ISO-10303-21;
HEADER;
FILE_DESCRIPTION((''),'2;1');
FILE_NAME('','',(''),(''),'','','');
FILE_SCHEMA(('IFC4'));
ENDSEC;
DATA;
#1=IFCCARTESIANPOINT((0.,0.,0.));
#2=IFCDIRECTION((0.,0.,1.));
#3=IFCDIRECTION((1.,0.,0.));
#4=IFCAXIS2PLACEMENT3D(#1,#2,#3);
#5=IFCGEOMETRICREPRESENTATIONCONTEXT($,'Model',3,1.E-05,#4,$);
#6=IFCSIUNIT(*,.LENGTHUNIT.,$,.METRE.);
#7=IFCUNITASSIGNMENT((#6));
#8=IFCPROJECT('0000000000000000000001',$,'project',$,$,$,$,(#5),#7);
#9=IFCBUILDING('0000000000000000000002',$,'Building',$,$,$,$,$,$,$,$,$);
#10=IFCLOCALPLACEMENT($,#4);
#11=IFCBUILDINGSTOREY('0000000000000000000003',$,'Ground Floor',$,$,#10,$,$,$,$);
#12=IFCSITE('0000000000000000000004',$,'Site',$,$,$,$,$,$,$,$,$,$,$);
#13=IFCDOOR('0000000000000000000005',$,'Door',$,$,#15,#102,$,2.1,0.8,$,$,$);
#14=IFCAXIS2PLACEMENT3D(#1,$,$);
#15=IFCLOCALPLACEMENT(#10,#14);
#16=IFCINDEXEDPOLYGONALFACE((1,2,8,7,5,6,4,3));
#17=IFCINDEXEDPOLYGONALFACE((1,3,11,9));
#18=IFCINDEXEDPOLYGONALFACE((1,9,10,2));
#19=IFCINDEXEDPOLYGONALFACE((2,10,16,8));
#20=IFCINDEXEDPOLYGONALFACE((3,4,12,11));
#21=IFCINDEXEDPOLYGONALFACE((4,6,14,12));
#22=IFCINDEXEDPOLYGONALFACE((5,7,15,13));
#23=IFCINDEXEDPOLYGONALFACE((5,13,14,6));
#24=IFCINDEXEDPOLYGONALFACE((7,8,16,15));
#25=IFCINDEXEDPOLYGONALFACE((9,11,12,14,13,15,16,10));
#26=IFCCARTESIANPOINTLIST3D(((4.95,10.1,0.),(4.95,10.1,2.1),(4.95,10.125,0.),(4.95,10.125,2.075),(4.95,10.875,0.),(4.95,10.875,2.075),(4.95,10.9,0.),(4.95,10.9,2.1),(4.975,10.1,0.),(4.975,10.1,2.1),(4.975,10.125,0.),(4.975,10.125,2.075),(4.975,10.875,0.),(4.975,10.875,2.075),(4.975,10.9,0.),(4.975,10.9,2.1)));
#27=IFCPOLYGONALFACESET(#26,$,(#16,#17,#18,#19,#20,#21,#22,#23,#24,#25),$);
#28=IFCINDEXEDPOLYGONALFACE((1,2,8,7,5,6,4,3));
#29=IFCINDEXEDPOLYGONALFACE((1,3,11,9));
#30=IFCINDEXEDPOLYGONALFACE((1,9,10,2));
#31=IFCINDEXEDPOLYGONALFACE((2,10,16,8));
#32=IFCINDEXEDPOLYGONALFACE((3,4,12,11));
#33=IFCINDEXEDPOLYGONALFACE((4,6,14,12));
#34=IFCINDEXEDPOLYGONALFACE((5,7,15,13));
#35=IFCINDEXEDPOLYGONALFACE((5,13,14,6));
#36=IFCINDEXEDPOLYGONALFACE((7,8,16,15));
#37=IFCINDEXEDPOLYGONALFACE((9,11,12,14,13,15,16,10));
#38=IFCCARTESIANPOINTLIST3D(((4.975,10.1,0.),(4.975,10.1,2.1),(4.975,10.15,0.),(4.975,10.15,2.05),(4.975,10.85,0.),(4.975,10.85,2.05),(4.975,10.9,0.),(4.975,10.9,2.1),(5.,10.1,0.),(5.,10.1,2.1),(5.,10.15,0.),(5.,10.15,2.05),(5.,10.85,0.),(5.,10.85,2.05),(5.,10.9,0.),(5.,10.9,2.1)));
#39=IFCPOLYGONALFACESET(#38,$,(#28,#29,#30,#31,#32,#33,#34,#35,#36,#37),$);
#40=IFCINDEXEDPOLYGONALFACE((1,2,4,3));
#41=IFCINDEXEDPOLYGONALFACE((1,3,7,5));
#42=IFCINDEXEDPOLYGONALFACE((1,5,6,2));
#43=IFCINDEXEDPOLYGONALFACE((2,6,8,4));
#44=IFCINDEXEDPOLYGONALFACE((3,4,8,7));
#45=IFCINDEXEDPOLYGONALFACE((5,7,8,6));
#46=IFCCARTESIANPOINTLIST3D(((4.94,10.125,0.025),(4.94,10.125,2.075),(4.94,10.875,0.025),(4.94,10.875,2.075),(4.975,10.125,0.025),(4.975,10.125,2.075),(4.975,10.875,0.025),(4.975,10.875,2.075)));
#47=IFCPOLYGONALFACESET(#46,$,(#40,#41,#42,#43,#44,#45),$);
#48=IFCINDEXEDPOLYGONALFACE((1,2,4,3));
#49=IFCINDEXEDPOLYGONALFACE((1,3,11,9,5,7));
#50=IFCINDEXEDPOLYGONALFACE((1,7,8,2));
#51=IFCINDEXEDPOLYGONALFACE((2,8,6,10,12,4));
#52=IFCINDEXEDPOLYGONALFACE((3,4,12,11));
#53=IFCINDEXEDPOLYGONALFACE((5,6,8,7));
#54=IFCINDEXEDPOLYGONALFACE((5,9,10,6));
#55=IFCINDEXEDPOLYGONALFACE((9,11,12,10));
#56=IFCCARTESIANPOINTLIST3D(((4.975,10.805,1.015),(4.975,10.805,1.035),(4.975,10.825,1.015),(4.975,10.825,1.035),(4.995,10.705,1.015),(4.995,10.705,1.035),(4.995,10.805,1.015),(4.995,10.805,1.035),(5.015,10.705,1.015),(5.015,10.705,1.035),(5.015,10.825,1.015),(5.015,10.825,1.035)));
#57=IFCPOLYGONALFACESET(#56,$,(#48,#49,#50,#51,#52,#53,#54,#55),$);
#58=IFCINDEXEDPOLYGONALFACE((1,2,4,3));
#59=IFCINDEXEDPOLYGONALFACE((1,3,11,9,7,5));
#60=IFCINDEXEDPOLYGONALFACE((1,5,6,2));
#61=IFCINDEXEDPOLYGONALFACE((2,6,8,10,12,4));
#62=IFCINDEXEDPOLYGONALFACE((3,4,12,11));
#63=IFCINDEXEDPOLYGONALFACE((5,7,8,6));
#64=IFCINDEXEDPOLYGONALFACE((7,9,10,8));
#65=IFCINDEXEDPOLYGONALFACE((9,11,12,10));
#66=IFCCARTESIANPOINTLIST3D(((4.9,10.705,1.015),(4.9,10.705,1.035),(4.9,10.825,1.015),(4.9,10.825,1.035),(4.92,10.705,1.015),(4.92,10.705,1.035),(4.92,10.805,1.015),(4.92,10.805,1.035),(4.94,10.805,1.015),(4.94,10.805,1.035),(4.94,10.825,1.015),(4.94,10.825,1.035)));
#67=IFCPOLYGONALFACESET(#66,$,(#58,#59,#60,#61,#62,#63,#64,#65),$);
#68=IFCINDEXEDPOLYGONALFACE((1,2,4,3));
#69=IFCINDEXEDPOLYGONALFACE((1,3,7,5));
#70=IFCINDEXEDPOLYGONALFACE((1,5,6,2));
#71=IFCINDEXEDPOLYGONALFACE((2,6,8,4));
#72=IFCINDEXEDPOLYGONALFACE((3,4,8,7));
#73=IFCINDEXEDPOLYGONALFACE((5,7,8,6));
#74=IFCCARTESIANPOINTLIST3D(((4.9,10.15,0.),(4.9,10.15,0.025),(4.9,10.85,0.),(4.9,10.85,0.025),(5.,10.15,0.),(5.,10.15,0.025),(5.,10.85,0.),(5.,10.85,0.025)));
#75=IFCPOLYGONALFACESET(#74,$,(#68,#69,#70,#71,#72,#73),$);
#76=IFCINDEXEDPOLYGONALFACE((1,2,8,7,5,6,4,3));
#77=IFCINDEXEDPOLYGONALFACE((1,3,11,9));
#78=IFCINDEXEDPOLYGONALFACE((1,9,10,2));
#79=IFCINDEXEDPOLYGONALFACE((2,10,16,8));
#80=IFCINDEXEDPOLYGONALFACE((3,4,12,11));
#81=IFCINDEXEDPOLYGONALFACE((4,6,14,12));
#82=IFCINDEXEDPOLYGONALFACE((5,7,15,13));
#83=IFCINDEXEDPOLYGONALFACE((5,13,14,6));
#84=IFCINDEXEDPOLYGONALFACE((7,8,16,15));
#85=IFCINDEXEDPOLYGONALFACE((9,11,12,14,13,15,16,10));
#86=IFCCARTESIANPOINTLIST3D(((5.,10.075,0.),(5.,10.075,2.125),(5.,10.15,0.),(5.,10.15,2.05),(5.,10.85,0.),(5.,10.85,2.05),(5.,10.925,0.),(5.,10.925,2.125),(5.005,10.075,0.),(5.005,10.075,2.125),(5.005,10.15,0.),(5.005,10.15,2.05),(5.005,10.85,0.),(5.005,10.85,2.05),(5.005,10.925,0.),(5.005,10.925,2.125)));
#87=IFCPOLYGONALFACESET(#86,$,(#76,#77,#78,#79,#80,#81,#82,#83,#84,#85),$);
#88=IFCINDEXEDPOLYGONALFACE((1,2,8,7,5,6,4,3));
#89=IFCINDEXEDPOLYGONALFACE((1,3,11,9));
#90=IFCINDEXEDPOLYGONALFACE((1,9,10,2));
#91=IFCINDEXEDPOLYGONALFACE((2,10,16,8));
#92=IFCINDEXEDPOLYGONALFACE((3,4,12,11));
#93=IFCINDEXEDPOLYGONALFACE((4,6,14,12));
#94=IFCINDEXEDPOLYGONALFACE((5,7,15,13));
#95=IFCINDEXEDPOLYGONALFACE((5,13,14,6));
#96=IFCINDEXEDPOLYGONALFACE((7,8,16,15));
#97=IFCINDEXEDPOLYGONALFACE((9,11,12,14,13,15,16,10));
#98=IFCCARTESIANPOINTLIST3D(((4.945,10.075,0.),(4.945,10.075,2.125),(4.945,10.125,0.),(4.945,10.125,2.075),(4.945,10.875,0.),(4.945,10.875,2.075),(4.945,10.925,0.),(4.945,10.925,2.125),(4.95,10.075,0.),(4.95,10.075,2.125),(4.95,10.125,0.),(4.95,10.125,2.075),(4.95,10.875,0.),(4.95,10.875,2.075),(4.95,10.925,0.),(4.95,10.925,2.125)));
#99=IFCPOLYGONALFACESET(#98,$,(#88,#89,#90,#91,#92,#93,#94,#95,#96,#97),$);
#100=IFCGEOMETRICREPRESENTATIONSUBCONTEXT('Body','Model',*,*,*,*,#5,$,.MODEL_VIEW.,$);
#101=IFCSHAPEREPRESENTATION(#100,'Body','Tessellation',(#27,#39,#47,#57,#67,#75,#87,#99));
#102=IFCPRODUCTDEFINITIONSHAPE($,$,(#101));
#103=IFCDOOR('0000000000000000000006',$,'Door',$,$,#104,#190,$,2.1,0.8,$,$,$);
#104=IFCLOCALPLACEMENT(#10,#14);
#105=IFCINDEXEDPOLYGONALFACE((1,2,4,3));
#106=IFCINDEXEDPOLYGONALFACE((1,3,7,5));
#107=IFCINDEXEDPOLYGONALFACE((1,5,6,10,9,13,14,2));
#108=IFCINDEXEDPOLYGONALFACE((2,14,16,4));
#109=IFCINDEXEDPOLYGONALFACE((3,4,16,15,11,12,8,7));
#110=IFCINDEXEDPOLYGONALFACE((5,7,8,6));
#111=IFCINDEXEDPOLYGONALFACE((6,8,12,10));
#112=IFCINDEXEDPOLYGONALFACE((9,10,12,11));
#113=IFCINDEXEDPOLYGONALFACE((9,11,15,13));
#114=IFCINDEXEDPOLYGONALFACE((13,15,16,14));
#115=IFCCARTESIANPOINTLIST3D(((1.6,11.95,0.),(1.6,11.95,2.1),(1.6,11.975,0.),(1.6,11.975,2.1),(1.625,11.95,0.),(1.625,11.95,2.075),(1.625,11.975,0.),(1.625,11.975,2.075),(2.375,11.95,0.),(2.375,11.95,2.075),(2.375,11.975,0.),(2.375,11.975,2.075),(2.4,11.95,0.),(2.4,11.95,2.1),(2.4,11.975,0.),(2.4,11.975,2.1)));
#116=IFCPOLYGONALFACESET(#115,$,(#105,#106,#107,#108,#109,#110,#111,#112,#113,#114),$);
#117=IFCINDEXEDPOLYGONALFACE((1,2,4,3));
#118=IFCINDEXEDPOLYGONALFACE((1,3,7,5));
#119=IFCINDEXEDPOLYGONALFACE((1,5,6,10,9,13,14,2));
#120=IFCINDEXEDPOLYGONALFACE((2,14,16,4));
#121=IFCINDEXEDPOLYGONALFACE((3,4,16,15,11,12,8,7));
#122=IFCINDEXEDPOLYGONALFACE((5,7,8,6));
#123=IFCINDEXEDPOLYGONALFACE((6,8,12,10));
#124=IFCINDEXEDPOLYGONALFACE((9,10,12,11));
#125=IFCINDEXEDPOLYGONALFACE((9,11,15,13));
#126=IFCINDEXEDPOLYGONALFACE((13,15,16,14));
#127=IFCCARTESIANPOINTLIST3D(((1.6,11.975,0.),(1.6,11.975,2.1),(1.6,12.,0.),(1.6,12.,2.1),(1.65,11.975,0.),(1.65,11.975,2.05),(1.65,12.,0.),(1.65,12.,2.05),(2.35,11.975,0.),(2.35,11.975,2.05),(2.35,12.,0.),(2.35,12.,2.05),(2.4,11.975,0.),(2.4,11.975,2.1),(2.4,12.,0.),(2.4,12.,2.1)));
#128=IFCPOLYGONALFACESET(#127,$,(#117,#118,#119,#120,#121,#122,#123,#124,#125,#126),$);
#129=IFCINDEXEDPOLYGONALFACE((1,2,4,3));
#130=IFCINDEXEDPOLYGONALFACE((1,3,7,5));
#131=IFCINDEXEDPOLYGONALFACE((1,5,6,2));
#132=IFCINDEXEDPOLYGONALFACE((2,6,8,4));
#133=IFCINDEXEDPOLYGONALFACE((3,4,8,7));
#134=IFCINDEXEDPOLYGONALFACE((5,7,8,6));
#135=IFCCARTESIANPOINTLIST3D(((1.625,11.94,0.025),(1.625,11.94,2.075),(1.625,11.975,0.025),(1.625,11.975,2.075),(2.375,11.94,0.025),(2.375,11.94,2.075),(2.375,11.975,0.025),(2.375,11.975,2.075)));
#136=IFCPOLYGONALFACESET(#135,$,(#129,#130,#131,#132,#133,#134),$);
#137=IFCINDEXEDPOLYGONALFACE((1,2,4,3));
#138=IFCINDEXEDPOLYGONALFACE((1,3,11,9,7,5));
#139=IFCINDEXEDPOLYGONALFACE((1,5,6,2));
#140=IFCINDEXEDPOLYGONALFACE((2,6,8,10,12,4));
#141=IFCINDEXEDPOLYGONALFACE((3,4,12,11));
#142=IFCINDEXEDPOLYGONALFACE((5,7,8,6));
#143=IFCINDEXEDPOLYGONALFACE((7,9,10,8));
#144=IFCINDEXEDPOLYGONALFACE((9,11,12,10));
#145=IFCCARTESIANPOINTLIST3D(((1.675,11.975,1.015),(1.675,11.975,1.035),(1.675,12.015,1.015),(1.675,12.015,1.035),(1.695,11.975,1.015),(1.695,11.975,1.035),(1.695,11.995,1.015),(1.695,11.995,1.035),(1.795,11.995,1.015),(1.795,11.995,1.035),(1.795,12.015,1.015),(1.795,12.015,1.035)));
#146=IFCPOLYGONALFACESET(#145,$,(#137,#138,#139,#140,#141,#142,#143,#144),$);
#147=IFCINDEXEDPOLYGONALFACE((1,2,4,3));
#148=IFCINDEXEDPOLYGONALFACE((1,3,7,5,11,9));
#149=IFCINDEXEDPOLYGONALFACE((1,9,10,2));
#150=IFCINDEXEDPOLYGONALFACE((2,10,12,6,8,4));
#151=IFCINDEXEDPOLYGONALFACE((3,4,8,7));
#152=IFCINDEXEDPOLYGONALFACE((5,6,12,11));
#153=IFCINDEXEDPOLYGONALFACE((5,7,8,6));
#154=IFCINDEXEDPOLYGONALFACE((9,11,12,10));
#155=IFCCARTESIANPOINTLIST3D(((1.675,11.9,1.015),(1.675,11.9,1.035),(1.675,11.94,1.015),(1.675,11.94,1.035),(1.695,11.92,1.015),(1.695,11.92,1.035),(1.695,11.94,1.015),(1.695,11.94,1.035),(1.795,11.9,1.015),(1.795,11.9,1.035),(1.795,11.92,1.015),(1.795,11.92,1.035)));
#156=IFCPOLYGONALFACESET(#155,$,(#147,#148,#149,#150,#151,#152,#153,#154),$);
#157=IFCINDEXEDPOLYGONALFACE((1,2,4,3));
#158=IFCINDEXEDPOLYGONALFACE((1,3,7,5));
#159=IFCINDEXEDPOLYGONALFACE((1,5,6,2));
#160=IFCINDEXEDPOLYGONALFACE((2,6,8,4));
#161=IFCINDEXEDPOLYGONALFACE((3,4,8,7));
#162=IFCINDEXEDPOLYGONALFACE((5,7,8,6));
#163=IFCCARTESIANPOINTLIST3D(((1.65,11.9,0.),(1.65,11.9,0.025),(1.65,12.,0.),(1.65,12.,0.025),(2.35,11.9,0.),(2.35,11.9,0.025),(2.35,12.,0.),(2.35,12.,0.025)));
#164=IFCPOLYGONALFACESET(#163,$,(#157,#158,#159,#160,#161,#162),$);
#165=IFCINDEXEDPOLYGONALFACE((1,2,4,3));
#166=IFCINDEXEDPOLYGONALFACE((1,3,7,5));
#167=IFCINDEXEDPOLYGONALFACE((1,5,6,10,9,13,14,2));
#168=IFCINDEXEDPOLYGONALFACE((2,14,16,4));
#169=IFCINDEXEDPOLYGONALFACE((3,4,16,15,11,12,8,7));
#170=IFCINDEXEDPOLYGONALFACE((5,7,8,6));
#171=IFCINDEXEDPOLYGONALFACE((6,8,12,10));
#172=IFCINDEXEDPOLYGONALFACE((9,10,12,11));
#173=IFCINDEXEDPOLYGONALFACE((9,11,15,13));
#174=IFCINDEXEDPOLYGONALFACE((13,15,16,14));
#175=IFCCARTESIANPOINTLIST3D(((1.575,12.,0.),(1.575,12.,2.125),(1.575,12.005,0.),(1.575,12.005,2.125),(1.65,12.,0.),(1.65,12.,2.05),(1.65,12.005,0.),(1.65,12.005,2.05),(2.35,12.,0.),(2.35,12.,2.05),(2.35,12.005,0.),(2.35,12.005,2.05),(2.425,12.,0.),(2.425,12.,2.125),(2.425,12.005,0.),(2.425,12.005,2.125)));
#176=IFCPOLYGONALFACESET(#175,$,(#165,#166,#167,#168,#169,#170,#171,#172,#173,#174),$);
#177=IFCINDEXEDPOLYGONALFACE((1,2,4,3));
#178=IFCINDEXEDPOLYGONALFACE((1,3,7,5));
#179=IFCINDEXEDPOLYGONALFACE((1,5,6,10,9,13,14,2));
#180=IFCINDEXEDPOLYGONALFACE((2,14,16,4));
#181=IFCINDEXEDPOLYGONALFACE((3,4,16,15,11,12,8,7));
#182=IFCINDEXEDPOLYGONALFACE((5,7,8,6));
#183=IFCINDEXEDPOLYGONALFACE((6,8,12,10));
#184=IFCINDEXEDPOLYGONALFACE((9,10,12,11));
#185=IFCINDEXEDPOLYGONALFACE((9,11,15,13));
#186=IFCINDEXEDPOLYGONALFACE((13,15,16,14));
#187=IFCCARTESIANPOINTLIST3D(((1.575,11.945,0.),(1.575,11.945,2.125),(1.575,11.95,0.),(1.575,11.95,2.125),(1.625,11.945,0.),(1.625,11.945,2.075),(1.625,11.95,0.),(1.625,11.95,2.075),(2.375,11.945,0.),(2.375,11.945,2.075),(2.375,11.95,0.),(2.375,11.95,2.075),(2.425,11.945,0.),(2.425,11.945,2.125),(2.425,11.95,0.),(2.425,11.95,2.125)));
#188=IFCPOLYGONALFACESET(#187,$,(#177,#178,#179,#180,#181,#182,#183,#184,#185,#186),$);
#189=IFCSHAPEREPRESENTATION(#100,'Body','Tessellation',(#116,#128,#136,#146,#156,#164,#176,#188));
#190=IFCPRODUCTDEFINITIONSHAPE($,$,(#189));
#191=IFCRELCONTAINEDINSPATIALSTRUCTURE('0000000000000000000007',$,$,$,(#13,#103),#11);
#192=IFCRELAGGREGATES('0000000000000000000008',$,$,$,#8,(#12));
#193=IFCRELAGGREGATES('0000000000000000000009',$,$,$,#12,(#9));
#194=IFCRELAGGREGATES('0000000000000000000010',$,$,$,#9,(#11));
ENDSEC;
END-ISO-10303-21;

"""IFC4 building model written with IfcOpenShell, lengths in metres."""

from ifc_helpers import new_model, si_unit, frame, origin_with_axes, place, context, subcontext, project, spatial, line, indexed_curve, outline, extrude, element, save


model = new_model("IFC4")

# Units and contexts
model_context = context("Model", 3, precision=1e-05, world=origin_with_axes())
body_context = subcontext(model_context, "Body", "Model", "MODEL_VIEW")
ifc_project = project(units=[si_unit("LENGTHUNIT", "METRE")], contexts=[model_context])

# Site, building, storey
site = spatial("IfcSite", under=ifc_project, Name="Site")
building = spatial("IfcBuilding", under=site, Name="Building")
storey_placement = place(None, origin_with_axes())
storey = spatial("IfcBuildingStorey", under=building, at=storey_placement, Name="Ground Floor")

# Doors
door_1_placement = place(storey_placement, frame((5.0, 10.1, 0.0), z_axis=(0.0, 0.0, 1.0), x_axis=(0.0, 1.0, 0.0)))
element("IfcDoor", 1, at=door_1_placement, inside=storey, Name="Door", OverallHeight=2.1, OverallWidth=0.8, context=body_context, shape_type="SweptSolid", body=[
    extrude(outline(indexed_curve([(0.0, 0.0), (0.0, 2.1), (0.8, 2.1), (0.8, 0.0), (0.775, 0.0), (0.775, 2.075), (0.025, 2.075), (0.025, 0.0)], segments=[line(1, 2, 3, 4, 5, 6, 7, 8, 1)])), frame((0.0, 0.025, 0.0), z_axis=(0.0, -1.0, 0.0), x_axis=(1.0, 0.0, 0.0)), (0.0, 0.0, -1.0), 0.025),
    extrude(outline(indexed_curve([(0.0, 0.0), (0.0, 2.1), (0.8, 2.1), (0.8, 0.0), (0.75, 0.0), (0.75, 2.05), (0.05, 2.05), (0.05, 0.0)], segments=[line(1, 2, 3, 4, 5, 6, 7, 8, 1)])), frame((0.0, 0.0, 0.0), z_axis=(0.0, -1.0, 0.0), x_axis=(1.0, 0.0, 0.0)), (0.0, 0.0, -1.0), 0.025),
    extrude(outline(indexed_curve([(0.0, 0.0), (0.75, 0.0), (0.75, 0.035), (0.0, 0.035)], segments=[line(1, 2, 3, 4, 1)])), frame((0.025, 0.025, 0.025), z_axis=(0.0, 0.0, 1.0), x_axis=(1.0, 0.0, 0.0)), (0.0, 0.0, 1.0), 2.05),
    extrude(outline(indexed_curve([(0.0, 0.0), (0.0, -0.04), (-0.12, -0.04), (-0.12, -0.02), (-0.02, -0.02), (-0.02, 0.0)], segments=[line(1, 2, 3, 4, 5, 6, 1)])), frame((0.725, 0.025, 1.015), z_axis=(0.0, 0.0, 1.0), x_axis=(1.0, 0.0, 0.0)), (0.0, 0.0, 1.0), 0.02),
    extrude(outline(indexed_curve([(0.0, 0.0), (0.0, 0.04), (-0.12, 0.04), (-0.12, 0.02), (-0.02, 0.02), (-0.02, 0.0)], segments=[line(1, 2, 3, 4, 5, 6, 1)])), frame((0.725, 0.06, 1.015), z_axis=(0.0, 0.0, 1.0), x_axis=(1.0, 0.0, 0.0)), (0.0, 0.0, 1.0), 0.02),
    extrude(outline(indexed_curve([(0.0, 0.0), (0.7, 0.0), (0.7, 0.1), (0.0, 0.1)], segments=[line(1, 2, 3, 4, 1)])), frame((0.05, 0.0, 0.0), z_axis=(0.0, 0.0, 1.0), x_axis=(1.0, 0.0, 0.0)), (0.0, 0.0, 1.0), 0.025),
    extrude(outline(indexed_curve([(0.0, 0.0), (0.0, 2.125), (0.85, 2.125), (0.85, 0.0), (0.775, 0.0), (0.775, 2.05), (0.075, 2.05), (0.075, 0.0)], segments=[line(1, 2, 3, 4, 5, 6, 7, 8, 1)])), frame((-0.025, -0.005, 0.0), z_axis=(0.0, -1.0, 0.0), x_axis=(1.0, 0.0, 0.0)), (0.0, 0.0, -1.0), 0.005),
    extrude(outline(indexed_curve([(0.0, 0.0), (0.0, 2.125), (0.85, 2.125), (0.85, 0.0), (0.8, 0.0), (0.8, 2.075), (0.05, 2.075), (0.05, 0.0)], segments=[line(1, 2, 3, 4, 5, 6, 7, 8, 1)])), frame((-0.025, 0.05, 0.0), z_axis=(0.0, -1.0, 0.0), x_axis=(1.0, 0.0, 0.0)), (0.0, 0.0, -1.0), 0.005),
])
door_2_placement = place(storey_placement, frame((2.4, 12.0, 0.0), z_axis=(0.0, 0.0, 1.0), x_axis=(-1.0, 0.0, 0.0)))
element("IfcDoor", 2, at=door_2_placement, inside=storey, Name="Door", OverallHeight=2.1, OverallWidth=0.8, context=body_context, shape_type="SweptSolid", body=[
    extrude(outline(indexed_curve([(0.0, 0.0), (0.0, 2.1), (0.8, 2.1), (0.8, 0.0), (0.775, 0.0), (0.775, 2.075), (0.025, 2.075), (0.025, 0.0)], segments=[line(1, 2, 3, 4, 5, 6, 7, 8, 1)])), frame((0.0, 0.025, 0.0), z_axis=(0.0, -1.0, 0.0), x_axis=(1.0, 0.0, 0.0)), (0.0, 0.0, -1.0), 0.025),
    extrude(outline(indexed_curve([(0.0, 0.0), (0.0, 2.1), (0.8, 2.1), (0.8, 0.0), (0.75, 0.0), (0.75, 2.05), (0.05, 2.05), (0.05, 0.0)], segments=[line(1, 2, 3, 4, 5, 6, 7, 8, 1)])), frame((0.0, 0.0, 0.0), z_axis=(0.0, -1.0, 0.0), x_axis=(1.0, 0.0, 0.0)), (0.0, 0.0, -1.0), 0.025),
    extrude(outline(indexed_curve([(0.0, 0.0), (0.75, 0.0), (0.75, 0.035), (0.0, 0.035)], segments=[line(1, 2, 3, 4, 1)])), frame((0.025, 0.025, 0.025), z_axis=(0.0, 0.0, 1.0), x_axis=(1.0, 0.0, 0.0)), (0.0, 0.0, 1.0), 2.05),
    extrude(outline(indexed_curve([(0.0, 0.0), (0.0, -0.04), (-0.12, -0.04), (-0.12, -0.02), (-0.02, -0.02), (-0.02, 0.0)], segments=[line(1, 2, 3, 4, 5, 6, 1)])), frame((0.725, 0.025, 1.015), z_axis=(0.0, 0.0, 1.0), x_axis=(1.0, 0.0, 0.0)), (0.0, 0.0, 1.0), 0.02),
    extrude(outline(indexed_curve([(0.0, 0.0), (0.0, 0.04), (-0.12, 0.04), (-0.12, 0.02), (-0.02, 0.02), (-0.02, 0.0)], segments=[line(1, 2, 3, 4, 5, 6, 1)])), frame((0.725, 0.06, 1.015), z_axis=(0.0, 0.0, 1.0), x_axis=(1.0, 0.0, 0.0)), (0.0, 0.0, 1.0), 0.02),
    extrude(outline(indexed_curve([(0.0, 0.0), (0.7, 0.0), (0.7, 0.1), (0.0, 0.1)], segments=[line(1, 2, 3, 4, 1)])), frame((0.05, 0.0, 0.0), z_axis=(0.0, 0.0, 1.0), x_axis=(1.0, 0.0, 0.0)), (0.0, 0.0, 1.0), 0.025),
    extrude(outline(indexed_curve([(0.0, 0.0), (0.0, 2.125), (0.85, 2.125), (0.85, 0.0), (0.775, 0.0), (0.775, 2.05), (0.075, 2.05), (0.075, 0.0)], segments=[line(1, 2, 3, 4, 5, 6, 7, 8, 1)])), frame((-0.025, -0.005, 0.0), z_axis=(0.0, -1.0, 0.0), x_axis=(1.0, 0.0, 0.0)), (0.0, 0.0, -1.0), 0.005),
    extrude(outline(indexed_curve([(0.0, 0.0), (0.0, 2.125), (0.85, 2.125), (0.85, 0.0), (0.8, 0.0), (0.8, 2.075), (0.05, 2.075), (0.05, 0.0)], segments=[line(1, 2, 3, 4, 5, 6, 7, 8, 1)])), frame((-0.025, 0.05, 0.0), z_axis=(0.0, -1.0, 0.0), x_axis=(1.0, 0.0, 0.0)), (0.0, 0.0, -1.0), 0.005),
])

save(model, "model.ifc")
